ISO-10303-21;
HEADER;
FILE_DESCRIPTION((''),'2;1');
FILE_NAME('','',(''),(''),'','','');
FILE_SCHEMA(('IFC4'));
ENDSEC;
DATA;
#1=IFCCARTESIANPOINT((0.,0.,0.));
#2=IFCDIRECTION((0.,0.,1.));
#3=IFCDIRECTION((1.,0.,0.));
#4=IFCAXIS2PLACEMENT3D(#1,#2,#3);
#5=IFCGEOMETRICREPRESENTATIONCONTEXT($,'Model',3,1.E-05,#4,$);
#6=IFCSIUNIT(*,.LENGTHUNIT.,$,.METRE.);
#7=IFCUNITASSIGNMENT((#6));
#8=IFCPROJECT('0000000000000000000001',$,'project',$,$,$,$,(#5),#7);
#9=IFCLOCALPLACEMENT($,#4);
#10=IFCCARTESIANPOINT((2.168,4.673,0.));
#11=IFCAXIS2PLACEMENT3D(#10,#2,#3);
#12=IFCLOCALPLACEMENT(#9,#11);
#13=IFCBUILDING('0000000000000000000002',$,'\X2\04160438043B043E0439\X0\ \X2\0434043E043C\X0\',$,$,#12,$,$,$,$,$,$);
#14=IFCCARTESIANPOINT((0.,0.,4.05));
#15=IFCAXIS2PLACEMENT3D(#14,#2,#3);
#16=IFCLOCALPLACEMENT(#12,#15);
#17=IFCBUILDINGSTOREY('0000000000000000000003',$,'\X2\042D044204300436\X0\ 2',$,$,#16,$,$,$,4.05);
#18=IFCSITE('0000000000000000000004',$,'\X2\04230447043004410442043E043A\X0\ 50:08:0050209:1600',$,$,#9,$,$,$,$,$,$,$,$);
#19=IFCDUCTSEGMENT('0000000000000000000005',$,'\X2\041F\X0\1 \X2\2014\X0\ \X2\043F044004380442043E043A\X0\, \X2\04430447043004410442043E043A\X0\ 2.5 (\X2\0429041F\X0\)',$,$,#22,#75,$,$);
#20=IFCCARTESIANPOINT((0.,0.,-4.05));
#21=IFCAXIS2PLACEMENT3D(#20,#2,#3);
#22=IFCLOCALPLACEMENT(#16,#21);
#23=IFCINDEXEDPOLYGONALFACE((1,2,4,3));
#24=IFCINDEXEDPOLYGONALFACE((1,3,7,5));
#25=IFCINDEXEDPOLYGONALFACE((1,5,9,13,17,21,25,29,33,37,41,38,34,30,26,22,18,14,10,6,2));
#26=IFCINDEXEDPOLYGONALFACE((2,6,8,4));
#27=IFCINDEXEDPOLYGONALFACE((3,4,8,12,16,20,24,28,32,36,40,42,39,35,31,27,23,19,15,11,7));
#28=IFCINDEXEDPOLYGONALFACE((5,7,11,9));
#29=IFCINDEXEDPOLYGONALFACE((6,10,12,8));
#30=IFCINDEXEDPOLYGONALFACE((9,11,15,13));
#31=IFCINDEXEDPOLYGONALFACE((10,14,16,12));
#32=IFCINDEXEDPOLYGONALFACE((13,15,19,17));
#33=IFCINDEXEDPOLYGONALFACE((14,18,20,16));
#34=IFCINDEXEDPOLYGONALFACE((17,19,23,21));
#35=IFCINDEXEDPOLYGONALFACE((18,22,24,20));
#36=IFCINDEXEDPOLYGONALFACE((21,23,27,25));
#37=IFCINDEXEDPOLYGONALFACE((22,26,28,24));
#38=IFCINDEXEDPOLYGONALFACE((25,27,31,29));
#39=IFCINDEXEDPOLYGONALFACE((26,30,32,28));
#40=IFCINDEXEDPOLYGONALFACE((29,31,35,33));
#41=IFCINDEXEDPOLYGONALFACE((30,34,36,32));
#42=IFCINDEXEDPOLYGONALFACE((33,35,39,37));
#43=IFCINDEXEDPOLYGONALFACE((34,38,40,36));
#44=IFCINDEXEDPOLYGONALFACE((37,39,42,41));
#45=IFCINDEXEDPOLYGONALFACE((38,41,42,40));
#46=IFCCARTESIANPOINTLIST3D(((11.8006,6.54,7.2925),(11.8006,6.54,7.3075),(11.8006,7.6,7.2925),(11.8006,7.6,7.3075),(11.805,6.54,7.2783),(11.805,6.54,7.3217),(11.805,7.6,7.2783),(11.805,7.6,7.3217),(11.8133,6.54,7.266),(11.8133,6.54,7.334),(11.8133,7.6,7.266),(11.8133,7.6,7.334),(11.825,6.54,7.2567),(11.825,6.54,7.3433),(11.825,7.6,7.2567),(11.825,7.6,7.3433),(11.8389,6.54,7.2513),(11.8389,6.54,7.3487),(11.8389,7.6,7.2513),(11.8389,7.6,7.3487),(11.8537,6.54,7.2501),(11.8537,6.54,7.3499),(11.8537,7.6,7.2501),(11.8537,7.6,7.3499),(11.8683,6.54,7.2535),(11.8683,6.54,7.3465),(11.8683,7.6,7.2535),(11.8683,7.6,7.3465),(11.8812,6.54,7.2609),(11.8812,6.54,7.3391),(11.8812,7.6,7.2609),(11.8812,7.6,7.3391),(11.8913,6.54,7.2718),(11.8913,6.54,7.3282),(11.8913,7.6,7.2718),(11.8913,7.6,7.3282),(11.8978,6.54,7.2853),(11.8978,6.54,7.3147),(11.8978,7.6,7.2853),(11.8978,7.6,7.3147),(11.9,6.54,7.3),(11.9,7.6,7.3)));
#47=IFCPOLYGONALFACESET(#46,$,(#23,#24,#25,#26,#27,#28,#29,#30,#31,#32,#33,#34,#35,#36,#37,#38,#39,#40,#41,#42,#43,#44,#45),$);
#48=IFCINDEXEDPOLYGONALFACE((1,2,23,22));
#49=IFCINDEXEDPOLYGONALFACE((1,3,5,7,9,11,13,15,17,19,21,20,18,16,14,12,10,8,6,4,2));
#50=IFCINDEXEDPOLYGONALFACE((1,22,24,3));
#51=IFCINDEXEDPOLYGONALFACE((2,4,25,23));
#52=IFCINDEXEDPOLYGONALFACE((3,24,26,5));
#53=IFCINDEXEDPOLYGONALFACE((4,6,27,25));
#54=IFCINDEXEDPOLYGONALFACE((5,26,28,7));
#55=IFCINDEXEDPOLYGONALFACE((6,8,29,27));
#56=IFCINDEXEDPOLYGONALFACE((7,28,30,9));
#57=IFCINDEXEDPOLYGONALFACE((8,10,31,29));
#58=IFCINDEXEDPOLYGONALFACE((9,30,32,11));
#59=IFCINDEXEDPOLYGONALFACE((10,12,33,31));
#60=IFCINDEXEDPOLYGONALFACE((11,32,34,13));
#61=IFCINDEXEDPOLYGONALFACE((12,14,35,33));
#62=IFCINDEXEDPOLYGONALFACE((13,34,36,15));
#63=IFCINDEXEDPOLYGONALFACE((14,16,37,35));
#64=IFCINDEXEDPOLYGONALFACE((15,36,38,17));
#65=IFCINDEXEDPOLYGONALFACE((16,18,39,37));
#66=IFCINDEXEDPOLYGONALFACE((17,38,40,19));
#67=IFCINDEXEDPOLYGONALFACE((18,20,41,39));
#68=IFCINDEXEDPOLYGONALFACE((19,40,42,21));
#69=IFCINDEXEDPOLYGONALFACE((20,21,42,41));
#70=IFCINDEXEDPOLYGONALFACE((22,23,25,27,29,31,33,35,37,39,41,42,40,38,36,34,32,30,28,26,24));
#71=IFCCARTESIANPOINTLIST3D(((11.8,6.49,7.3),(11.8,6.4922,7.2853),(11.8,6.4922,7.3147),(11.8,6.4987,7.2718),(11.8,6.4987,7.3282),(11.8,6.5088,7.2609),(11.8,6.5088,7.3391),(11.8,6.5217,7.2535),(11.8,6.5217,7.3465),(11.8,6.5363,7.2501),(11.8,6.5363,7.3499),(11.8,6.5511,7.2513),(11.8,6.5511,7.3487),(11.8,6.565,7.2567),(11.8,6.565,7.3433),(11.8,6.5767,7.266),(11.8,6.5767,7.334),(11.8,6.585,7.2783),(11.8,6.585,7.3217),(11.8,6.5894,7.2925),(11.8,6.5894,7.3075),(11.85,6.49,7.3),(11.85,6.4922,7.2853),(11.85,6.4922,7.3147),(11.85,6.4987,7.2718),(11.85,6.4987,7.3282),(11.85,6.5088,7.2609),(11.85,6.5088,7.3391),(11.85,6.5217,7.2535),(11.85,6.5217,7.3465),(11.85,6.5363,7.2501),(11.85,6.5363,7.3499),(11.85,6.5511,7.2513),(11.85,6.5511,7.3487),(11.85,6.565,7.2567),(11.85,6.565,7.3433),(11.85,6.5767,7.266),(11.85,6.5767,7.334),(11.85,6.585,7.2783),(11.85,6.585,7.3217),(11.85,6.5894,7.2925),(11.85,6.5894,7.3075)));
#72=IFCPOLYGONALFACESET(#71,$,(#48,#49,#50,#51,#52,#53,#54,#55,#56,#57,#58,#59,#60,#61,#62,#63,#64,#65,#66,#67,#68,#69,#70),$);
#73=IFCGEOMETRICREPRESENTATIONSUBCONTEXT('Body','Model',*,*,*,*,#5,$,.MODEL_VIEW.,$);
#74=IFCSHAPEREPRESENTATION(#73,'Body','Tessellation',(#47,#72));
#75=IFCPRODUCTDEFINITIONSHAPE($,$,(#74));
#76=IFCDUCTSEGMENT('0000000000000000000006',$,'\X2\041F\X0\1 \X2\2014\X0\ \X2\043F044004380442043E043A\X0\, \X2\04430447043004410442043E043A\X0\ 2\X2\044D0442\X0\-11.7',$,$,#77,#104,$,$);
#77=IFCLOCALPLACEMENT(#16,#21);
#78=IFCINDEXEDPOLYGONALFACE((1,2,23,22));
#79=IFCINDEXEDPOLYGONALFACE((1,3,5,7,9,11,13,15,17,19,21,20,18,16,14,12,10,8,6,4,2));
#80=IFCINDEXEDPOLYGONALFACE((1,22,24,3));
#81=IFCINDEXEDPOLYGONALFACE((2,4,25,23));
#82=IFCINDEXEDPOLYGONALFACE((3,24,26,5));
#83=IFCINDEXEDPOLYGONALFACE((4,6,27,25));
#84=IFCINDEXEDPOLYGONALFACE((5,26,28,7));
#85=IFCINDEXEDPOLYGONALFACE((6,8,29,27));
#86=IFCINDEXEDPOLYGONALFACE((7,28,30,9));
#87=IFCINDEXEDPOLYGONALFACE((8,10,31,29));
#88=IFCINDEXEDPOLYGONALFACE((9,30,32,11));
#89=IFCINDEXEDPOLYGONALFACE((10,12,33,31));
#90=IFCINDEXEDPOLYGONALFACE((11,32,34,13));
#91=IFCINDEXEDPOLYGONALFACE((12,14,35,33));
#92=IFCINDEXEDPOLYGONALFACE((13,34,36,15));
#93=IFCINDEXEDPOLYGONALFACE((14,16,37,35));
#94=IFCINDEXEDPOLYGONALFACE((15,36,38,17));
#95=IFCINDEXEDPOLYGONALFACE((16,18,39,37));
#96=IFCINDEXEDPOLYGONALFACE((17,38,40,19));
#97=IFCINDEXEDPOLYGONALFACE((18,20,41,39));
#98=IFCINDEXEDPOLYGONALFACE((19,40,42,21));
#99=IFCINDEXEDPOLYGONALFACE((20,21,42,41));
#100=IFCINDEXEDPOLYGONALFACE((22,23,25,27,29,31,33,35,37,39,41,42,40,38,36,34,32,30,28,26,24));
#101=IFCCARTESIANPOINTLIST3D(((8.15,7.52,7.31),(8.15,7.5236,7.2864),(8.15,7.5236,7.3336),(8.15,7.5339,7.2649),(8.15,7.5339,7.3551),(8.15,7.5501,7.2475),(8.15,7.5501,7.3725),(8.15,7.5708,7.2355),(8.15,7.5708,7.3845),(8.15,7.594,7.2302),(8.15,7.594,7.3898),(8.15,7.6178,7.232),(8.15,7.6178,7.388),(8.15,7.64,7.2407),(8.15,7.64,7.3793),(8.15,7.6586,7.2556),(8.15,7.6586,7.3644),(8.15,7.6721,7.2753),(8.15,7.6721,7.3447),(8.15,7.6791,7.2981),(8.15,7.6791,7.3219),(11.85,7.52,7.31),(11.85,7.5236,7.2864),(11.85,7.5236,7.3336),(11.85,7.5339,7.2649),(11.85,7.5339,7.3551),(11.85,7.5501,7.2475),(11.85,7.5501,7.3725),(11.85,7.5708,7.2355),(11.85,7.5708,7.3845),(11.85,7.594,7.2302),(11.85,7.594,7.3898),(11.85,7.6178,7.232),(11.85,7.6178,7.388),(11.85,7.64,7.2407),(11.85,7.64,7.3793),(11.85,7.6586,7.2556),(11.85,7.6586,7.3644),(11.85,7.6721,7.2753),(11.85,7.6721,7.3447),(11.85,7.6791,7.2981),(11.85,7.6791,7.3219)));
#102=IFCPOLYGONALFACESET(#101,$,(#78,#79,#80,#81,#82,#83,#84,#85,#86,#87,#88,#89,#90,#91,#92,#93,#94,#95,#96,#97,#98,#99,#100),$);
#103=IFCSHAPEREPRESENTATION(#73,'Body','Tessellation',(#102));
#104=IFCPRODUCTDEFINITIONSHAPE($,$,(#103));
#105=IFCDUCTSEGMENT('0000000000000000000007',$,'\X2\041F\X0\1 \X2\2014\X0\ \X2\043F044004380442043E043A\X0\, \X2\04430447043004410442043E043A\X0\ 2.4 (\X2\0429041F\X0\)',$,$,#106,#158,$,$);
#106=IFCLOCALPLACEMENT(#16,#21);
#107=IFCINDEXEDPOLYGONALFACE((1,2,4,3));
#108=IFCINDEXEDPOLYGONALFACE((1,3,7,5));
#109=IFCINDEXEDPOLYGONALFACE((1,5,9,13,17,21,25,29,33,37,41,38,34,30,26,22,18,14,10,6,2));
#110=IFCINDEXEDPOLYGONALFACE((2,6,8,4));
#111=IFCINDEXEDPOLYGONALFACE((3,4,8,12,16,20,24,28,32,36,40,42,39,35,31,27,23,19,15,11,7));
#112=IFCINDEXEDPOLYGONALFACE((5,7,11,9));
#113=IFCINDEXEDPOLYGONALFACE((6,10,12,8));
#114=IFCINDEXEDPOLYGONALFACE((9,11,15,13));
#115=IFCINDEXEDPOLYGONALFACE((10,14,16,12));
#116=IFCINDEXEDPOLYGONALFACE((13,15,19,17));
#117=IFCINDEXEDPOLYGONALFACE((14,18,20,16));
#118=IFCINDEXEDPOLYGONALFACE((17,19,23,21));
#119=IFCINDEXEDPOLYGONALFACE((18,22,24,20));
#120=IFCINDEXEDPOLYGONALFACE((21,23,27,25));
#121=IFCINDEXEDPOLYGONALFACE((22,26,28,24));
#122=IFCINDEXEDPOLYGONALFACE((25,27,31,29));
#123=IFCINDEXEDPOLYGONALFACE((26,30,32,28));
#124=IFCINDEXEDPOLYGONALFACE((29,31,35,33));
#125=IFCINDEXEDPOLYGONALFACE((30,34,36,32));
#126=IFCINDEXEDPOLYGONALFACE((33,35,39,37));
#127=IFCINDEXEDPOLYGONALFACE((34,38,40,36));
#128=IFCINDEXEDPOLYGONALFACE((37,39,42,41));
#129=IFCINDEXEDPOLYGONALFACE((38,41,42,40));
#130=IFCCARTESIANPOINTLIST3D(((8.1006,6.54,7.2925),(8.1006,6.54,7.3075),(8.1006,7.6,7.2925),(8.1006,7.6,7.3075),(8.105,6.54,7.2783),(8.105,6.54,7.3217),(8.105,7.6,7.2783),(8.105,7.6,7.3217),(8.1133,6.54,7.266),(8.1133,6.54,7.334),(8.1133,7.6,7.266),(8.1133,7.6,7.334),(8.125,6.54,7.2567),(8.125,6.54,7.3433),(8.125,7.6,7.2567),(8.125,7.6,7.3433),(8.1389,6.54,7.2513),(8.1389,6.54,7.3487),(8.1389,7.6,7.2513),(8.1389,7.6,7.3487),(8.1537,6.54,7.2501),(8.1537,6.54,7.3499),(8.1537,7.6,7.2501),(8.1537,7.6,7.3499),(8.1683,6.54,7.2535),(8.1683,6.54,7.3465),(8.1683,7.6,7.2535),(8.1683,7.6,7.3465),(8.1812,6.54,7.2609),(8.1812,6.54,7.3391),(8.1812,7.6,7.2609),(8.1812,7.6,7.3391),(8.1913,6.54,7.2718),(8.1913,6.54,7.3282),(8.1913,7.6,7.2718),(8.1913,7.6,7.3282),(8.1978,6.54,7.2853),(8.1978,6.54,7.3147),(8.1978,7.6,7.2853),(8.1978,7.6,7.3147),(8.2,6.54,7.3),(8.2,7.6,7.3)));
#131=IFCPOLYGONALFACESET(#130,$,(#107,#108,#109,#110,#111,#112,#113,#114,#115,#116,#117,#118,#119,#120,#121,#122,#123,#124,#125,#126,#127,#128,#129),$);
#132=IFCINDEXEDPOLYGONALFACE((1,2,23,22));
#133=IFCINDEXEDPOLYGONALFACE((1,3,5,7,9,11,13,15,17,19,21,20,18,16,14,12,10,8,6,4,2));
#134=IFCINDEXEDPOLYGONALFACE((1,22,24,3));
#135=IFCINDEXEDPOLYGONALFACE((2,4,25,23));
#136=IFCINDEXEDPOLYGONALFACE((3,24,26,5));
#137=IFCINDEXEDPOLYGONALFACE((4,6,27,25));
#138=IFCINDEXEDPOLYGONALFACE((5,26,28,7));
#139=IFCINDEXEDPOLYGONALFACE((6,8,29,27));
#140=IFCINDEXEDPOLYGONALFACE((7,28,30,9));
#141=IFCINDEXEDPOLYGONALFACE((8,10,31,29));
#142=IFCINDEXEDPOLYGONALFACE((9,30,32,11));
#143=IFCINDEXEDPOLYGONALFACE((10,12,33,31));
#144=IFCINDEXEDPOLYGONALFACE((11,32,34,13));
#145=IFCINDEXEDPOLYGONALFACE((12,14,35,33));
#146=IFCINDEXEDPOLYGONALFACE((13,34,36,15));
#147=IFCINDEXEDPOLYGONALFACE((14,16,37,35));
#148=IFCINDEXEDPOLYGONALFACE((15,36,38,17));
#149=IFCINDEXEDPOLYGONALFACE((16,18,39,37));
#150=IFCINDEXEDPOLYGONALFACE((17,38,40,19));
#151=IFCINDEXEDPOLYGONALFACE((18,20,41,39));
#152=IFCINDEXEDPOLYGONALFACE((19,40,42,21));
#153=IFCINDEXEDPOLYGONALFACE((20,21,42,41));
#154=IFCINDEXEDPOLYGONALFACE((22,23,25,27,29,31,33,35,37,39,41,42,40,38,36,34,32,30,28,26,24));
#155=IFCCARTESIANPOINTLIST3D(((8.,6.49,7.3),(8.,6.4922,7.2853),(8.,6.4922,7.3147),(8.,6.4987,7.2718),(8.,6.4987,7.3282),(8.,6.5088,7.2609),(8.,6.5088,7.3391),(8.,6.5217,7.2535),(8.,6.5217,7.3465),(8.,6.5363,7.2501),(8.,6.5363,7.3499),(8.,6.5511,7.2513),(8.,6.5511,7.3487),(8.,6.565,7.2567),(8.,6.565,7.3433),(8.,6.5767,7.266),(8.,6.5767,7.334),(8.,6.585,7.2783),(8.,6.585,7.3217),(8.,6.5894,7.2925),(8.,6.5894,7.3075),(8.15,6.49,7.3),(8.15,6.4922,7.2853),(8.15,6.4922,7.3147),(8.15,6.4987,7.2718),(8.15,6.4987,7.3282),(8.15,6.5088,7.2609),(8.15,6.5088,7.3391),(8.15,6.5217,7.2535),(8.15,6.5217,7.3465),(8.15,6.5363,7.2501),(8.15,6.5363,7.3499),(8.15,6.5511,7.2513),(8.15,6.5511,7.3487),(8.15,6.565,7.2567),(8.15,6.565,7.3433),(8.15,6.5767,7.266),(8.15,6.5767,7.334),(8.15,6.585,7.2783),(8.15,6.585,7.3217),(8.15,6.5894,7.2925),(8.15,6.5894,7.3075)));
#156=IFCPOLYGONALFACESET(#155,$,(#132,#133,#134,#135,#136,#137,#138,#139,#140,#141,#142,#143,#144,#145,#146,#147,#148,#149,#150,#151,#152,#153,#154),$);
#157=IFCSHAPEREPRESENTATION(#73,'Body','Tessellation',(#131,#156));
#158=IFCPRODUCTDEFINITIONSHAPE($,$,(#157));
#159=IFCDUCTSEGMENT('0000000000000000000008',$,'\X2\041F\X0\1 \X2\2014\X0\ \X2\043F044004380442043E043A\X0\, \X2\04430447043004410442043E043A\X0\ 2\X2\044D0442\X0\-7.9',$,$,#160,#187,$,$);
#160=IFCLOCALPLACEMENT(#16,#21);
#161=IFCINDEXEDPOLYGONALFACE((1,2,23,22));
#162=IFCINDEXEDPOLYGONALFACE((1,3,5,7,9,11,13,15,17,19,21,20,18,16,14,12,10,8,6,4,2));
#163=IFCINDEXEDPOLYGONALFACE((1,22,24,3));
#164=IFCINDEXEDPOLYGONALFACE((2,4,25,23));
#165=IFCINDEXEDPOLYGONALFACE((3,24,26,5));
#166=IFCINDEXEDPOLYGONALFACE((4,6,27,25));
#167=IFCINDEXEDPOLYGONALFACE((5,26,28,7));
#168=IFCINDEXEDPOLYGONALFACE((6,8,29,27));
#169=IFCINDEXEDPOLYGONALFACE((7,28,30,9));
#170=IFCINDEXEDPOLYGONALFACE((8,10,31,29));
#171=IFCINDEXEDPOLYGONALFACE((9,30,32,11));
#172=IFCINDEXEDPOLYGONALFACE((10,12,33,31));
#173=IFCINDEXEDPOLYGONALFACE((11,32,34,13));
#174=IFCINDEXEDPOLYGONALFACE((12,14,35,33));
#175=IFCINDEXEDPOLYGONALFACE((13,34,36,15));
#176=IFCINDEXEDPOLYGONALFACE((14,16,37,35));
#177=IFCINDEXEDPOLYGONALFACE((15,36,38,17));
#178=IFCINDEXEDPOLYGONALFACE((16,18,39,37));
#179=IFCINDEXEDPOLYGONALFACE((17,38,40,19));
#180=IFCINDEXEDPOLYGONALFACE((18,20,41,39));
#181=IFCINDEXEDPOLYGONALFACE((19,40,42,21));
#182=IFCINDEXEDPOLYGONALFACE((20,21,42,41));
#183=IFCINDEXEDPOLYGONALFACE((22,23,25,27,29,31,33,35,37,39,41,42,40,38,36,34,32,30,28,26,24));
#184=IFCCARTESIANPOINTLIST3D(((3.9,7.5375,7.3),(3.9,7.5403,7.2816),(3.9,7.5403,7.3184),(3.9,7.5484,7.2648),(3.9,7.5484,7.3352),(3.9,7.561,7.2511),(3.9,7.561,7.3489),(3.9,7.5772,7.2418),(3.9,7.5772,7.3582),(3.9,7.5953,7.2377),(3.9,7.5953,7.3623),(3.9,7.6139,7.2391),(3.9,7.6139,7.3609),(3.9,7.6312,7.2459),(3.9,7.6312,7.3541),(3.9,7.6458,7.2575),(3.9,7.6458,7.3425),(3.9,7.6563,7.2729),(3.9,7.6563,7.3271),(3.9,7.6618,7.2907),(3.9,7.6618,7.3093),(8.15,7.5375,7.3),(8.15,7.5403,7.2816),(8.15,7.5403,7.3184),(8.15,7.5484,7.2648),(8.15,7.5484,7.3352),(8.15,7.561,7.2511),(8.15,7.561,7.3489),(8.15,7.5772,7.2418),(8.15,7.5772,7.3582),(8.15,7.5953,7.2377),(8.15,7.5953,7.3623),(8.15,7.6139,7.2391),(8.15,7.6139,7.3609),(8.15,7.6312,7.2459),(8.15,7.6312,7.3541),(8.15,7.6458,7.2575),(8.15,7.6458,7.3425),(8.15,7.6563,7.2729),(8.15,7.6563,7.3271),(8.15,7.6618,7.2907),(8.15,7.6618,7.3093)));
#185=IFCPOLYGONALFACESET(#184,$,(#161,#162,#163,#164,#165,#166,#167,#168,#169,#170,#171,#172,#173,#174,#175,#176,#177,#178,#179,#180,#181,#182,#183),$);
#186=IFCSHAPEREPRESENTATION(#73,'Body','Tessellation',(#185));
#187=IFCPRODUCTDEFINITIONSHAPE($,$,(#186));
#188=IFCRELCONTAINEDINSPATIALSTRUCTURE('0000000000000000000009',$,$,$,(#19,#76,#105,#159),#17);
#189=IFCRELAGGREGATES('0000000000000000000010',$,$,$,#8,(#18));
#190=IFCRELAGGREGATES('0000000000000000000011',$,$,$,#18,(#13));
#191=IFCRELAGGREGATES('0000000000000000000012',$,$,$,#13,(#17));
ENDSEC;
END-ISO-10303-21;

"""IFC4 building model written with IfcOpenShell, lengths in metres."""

from ifc_helpers import new_model, si_unit, frame, origin_with_axes, origin_2d, place, context, subcontext, project, spatial, circle, extrude, element, save


model = new_model("IFC4")

# Units and contexts
model_context = context("Model", 3, precision=1e-05, world=origin_with_axes())
body_context = subcontext(model_context, "Body", "Model", "MODEL_VIEW")
ifc_project = project(units=[si_unit("LENGTHUNIT", "METRE")], contexts=[model_context])

# Site, building, storey
site_placement = place(None, origin_with_axes())
site = spatial("IfcSite", under=ifc_project, at=site_placement, Name="Участок 50:08:0050209:1600")
building_placement = place(site_placement, frame((2.168, 4.673, 0.0), z_axis=(0.0, 0.0, 1.0), x_axis=(1.0, 0.0, 0.0)))
building = spatial("IfcBuilding", under=site, at=building_placement, Name="Жилой дом")
storey_placement = place(building_placement, frame((0.0, 0.0, 4.05), z_axis=(0.0, 0.0, 1.0), x_axis=(1.0, 0.0, 0.0)))
storey = spatial("IfcBuildingStorey", under=building, at=storey_placement, Name="Этаж 2", Elevation=4.05)

# Duct segments
duct_segment_1_placement = place(storey_placement, frame((0.0, 0.0, -4.05), z_axis=(0.0, 0.0, 1.0), x_axis=(1.0, 0.0, 0.0)))
element("IfcDuctSegment", 1, at=duct_segment_1_placement, inside=storey, Name="П1 — приток, участок 2.5 (ЩП)", context=body_context, shape_type="SweptSolid", body=[
    extrude(circle(Radius=0.05, at=origin_2d()), frame((11.85, 7.6, 7.3), z_axis=(0.0, -1.0, 0.0), x_axis=(1.0, 0.0, 0.0)), (0.0, 0.0, 1.0), 1.06),
    extrude(circle(Radius=0.05, at=origin_2d()), frame((11.85, 6.54, 7.3), z_axis=(-1.0, 0.0, 0.0), x_axis=(0.0, -1.0, 0.0)), (0.0, 0.0, 1.0), 0.05),
])
duct_segment_2_placement = place(storey_placement, frame((0.0, 0.0, -4.05), z_axis=(0.0, 0.0, 1.0), x_axis=(1.0, 0.0, 0.0)))
element("IfcDuctSegment", 2, at=duct_segment_2_placement, inside=storey, Name="П1 — приток, участок 2эт-11.7", context=body_context, shape_type="SweptSolid", body=[
    extrude(circle(Radius=0.08, at=origin_2d()), frame((11.85, 7.6, 7.31), z_axis=(-1.0, 0.0, 0.0), x_axis=(0.0, -1.0, 0.0)), (0.0, 0.0, 1.0), 3.7),
])
duct_segment_3_placement = place(storey_placement, frame((0.0, 0.0, -4.05), z_axis=(0.0, 0.0, 1.0), x_axis=(1.0, 0.0, 0.0)))
element("IfcDuctSegment", 3, at=duct_segment_3_placement, inside=storey, Name="П1 — приток, участок 2.4 (ЩП)", context=body_context, shape_type="SweptSolid", body=[
    extrude(circle(Radius=0.05, at=origin_2d()), frame((8.15, 7.6, 7.3), z_axis=(0.0, -1.0, 0.0), x_axis=(1.0, 0.0, 0.0)), (0.0, 0.0, 1.0), 1.06),
    extrude(circle(Radius=0.05, at=origin_2d()), frame((8.15, 6.54, 7.3), z_axis=(-1.0, 0.0, 0.0), x_axis=(0.0, -1.0, 0.0)), (0.0, 0.0, 1.0), 0.15),
])
duct_segment_4_placement = place(storey_placement, frame((0.0, 0.0, -4.05), z_axis=(0.0, 0.0, 1.0), x_axis=(1.0, 0.0, 0.0)))
element("IfcDuctSegment", 4, at=duct_segment_4_placement, inside=storey, Name="П1 — приток, участок 2эт-7.9", context=body_context, shape_type="SweptSolid", body=[
    extrude(circle(Radius=0.0625, at=origin_2d()), frame((8.15, 7.6, 7.3), z_axis=(-1.0, 0.0, 0.0), x_axis=(0.0, -1.0, 0.0)), (0.0, 0.0, 1.0), 4.25),
])

save(model, "model.ifc")
